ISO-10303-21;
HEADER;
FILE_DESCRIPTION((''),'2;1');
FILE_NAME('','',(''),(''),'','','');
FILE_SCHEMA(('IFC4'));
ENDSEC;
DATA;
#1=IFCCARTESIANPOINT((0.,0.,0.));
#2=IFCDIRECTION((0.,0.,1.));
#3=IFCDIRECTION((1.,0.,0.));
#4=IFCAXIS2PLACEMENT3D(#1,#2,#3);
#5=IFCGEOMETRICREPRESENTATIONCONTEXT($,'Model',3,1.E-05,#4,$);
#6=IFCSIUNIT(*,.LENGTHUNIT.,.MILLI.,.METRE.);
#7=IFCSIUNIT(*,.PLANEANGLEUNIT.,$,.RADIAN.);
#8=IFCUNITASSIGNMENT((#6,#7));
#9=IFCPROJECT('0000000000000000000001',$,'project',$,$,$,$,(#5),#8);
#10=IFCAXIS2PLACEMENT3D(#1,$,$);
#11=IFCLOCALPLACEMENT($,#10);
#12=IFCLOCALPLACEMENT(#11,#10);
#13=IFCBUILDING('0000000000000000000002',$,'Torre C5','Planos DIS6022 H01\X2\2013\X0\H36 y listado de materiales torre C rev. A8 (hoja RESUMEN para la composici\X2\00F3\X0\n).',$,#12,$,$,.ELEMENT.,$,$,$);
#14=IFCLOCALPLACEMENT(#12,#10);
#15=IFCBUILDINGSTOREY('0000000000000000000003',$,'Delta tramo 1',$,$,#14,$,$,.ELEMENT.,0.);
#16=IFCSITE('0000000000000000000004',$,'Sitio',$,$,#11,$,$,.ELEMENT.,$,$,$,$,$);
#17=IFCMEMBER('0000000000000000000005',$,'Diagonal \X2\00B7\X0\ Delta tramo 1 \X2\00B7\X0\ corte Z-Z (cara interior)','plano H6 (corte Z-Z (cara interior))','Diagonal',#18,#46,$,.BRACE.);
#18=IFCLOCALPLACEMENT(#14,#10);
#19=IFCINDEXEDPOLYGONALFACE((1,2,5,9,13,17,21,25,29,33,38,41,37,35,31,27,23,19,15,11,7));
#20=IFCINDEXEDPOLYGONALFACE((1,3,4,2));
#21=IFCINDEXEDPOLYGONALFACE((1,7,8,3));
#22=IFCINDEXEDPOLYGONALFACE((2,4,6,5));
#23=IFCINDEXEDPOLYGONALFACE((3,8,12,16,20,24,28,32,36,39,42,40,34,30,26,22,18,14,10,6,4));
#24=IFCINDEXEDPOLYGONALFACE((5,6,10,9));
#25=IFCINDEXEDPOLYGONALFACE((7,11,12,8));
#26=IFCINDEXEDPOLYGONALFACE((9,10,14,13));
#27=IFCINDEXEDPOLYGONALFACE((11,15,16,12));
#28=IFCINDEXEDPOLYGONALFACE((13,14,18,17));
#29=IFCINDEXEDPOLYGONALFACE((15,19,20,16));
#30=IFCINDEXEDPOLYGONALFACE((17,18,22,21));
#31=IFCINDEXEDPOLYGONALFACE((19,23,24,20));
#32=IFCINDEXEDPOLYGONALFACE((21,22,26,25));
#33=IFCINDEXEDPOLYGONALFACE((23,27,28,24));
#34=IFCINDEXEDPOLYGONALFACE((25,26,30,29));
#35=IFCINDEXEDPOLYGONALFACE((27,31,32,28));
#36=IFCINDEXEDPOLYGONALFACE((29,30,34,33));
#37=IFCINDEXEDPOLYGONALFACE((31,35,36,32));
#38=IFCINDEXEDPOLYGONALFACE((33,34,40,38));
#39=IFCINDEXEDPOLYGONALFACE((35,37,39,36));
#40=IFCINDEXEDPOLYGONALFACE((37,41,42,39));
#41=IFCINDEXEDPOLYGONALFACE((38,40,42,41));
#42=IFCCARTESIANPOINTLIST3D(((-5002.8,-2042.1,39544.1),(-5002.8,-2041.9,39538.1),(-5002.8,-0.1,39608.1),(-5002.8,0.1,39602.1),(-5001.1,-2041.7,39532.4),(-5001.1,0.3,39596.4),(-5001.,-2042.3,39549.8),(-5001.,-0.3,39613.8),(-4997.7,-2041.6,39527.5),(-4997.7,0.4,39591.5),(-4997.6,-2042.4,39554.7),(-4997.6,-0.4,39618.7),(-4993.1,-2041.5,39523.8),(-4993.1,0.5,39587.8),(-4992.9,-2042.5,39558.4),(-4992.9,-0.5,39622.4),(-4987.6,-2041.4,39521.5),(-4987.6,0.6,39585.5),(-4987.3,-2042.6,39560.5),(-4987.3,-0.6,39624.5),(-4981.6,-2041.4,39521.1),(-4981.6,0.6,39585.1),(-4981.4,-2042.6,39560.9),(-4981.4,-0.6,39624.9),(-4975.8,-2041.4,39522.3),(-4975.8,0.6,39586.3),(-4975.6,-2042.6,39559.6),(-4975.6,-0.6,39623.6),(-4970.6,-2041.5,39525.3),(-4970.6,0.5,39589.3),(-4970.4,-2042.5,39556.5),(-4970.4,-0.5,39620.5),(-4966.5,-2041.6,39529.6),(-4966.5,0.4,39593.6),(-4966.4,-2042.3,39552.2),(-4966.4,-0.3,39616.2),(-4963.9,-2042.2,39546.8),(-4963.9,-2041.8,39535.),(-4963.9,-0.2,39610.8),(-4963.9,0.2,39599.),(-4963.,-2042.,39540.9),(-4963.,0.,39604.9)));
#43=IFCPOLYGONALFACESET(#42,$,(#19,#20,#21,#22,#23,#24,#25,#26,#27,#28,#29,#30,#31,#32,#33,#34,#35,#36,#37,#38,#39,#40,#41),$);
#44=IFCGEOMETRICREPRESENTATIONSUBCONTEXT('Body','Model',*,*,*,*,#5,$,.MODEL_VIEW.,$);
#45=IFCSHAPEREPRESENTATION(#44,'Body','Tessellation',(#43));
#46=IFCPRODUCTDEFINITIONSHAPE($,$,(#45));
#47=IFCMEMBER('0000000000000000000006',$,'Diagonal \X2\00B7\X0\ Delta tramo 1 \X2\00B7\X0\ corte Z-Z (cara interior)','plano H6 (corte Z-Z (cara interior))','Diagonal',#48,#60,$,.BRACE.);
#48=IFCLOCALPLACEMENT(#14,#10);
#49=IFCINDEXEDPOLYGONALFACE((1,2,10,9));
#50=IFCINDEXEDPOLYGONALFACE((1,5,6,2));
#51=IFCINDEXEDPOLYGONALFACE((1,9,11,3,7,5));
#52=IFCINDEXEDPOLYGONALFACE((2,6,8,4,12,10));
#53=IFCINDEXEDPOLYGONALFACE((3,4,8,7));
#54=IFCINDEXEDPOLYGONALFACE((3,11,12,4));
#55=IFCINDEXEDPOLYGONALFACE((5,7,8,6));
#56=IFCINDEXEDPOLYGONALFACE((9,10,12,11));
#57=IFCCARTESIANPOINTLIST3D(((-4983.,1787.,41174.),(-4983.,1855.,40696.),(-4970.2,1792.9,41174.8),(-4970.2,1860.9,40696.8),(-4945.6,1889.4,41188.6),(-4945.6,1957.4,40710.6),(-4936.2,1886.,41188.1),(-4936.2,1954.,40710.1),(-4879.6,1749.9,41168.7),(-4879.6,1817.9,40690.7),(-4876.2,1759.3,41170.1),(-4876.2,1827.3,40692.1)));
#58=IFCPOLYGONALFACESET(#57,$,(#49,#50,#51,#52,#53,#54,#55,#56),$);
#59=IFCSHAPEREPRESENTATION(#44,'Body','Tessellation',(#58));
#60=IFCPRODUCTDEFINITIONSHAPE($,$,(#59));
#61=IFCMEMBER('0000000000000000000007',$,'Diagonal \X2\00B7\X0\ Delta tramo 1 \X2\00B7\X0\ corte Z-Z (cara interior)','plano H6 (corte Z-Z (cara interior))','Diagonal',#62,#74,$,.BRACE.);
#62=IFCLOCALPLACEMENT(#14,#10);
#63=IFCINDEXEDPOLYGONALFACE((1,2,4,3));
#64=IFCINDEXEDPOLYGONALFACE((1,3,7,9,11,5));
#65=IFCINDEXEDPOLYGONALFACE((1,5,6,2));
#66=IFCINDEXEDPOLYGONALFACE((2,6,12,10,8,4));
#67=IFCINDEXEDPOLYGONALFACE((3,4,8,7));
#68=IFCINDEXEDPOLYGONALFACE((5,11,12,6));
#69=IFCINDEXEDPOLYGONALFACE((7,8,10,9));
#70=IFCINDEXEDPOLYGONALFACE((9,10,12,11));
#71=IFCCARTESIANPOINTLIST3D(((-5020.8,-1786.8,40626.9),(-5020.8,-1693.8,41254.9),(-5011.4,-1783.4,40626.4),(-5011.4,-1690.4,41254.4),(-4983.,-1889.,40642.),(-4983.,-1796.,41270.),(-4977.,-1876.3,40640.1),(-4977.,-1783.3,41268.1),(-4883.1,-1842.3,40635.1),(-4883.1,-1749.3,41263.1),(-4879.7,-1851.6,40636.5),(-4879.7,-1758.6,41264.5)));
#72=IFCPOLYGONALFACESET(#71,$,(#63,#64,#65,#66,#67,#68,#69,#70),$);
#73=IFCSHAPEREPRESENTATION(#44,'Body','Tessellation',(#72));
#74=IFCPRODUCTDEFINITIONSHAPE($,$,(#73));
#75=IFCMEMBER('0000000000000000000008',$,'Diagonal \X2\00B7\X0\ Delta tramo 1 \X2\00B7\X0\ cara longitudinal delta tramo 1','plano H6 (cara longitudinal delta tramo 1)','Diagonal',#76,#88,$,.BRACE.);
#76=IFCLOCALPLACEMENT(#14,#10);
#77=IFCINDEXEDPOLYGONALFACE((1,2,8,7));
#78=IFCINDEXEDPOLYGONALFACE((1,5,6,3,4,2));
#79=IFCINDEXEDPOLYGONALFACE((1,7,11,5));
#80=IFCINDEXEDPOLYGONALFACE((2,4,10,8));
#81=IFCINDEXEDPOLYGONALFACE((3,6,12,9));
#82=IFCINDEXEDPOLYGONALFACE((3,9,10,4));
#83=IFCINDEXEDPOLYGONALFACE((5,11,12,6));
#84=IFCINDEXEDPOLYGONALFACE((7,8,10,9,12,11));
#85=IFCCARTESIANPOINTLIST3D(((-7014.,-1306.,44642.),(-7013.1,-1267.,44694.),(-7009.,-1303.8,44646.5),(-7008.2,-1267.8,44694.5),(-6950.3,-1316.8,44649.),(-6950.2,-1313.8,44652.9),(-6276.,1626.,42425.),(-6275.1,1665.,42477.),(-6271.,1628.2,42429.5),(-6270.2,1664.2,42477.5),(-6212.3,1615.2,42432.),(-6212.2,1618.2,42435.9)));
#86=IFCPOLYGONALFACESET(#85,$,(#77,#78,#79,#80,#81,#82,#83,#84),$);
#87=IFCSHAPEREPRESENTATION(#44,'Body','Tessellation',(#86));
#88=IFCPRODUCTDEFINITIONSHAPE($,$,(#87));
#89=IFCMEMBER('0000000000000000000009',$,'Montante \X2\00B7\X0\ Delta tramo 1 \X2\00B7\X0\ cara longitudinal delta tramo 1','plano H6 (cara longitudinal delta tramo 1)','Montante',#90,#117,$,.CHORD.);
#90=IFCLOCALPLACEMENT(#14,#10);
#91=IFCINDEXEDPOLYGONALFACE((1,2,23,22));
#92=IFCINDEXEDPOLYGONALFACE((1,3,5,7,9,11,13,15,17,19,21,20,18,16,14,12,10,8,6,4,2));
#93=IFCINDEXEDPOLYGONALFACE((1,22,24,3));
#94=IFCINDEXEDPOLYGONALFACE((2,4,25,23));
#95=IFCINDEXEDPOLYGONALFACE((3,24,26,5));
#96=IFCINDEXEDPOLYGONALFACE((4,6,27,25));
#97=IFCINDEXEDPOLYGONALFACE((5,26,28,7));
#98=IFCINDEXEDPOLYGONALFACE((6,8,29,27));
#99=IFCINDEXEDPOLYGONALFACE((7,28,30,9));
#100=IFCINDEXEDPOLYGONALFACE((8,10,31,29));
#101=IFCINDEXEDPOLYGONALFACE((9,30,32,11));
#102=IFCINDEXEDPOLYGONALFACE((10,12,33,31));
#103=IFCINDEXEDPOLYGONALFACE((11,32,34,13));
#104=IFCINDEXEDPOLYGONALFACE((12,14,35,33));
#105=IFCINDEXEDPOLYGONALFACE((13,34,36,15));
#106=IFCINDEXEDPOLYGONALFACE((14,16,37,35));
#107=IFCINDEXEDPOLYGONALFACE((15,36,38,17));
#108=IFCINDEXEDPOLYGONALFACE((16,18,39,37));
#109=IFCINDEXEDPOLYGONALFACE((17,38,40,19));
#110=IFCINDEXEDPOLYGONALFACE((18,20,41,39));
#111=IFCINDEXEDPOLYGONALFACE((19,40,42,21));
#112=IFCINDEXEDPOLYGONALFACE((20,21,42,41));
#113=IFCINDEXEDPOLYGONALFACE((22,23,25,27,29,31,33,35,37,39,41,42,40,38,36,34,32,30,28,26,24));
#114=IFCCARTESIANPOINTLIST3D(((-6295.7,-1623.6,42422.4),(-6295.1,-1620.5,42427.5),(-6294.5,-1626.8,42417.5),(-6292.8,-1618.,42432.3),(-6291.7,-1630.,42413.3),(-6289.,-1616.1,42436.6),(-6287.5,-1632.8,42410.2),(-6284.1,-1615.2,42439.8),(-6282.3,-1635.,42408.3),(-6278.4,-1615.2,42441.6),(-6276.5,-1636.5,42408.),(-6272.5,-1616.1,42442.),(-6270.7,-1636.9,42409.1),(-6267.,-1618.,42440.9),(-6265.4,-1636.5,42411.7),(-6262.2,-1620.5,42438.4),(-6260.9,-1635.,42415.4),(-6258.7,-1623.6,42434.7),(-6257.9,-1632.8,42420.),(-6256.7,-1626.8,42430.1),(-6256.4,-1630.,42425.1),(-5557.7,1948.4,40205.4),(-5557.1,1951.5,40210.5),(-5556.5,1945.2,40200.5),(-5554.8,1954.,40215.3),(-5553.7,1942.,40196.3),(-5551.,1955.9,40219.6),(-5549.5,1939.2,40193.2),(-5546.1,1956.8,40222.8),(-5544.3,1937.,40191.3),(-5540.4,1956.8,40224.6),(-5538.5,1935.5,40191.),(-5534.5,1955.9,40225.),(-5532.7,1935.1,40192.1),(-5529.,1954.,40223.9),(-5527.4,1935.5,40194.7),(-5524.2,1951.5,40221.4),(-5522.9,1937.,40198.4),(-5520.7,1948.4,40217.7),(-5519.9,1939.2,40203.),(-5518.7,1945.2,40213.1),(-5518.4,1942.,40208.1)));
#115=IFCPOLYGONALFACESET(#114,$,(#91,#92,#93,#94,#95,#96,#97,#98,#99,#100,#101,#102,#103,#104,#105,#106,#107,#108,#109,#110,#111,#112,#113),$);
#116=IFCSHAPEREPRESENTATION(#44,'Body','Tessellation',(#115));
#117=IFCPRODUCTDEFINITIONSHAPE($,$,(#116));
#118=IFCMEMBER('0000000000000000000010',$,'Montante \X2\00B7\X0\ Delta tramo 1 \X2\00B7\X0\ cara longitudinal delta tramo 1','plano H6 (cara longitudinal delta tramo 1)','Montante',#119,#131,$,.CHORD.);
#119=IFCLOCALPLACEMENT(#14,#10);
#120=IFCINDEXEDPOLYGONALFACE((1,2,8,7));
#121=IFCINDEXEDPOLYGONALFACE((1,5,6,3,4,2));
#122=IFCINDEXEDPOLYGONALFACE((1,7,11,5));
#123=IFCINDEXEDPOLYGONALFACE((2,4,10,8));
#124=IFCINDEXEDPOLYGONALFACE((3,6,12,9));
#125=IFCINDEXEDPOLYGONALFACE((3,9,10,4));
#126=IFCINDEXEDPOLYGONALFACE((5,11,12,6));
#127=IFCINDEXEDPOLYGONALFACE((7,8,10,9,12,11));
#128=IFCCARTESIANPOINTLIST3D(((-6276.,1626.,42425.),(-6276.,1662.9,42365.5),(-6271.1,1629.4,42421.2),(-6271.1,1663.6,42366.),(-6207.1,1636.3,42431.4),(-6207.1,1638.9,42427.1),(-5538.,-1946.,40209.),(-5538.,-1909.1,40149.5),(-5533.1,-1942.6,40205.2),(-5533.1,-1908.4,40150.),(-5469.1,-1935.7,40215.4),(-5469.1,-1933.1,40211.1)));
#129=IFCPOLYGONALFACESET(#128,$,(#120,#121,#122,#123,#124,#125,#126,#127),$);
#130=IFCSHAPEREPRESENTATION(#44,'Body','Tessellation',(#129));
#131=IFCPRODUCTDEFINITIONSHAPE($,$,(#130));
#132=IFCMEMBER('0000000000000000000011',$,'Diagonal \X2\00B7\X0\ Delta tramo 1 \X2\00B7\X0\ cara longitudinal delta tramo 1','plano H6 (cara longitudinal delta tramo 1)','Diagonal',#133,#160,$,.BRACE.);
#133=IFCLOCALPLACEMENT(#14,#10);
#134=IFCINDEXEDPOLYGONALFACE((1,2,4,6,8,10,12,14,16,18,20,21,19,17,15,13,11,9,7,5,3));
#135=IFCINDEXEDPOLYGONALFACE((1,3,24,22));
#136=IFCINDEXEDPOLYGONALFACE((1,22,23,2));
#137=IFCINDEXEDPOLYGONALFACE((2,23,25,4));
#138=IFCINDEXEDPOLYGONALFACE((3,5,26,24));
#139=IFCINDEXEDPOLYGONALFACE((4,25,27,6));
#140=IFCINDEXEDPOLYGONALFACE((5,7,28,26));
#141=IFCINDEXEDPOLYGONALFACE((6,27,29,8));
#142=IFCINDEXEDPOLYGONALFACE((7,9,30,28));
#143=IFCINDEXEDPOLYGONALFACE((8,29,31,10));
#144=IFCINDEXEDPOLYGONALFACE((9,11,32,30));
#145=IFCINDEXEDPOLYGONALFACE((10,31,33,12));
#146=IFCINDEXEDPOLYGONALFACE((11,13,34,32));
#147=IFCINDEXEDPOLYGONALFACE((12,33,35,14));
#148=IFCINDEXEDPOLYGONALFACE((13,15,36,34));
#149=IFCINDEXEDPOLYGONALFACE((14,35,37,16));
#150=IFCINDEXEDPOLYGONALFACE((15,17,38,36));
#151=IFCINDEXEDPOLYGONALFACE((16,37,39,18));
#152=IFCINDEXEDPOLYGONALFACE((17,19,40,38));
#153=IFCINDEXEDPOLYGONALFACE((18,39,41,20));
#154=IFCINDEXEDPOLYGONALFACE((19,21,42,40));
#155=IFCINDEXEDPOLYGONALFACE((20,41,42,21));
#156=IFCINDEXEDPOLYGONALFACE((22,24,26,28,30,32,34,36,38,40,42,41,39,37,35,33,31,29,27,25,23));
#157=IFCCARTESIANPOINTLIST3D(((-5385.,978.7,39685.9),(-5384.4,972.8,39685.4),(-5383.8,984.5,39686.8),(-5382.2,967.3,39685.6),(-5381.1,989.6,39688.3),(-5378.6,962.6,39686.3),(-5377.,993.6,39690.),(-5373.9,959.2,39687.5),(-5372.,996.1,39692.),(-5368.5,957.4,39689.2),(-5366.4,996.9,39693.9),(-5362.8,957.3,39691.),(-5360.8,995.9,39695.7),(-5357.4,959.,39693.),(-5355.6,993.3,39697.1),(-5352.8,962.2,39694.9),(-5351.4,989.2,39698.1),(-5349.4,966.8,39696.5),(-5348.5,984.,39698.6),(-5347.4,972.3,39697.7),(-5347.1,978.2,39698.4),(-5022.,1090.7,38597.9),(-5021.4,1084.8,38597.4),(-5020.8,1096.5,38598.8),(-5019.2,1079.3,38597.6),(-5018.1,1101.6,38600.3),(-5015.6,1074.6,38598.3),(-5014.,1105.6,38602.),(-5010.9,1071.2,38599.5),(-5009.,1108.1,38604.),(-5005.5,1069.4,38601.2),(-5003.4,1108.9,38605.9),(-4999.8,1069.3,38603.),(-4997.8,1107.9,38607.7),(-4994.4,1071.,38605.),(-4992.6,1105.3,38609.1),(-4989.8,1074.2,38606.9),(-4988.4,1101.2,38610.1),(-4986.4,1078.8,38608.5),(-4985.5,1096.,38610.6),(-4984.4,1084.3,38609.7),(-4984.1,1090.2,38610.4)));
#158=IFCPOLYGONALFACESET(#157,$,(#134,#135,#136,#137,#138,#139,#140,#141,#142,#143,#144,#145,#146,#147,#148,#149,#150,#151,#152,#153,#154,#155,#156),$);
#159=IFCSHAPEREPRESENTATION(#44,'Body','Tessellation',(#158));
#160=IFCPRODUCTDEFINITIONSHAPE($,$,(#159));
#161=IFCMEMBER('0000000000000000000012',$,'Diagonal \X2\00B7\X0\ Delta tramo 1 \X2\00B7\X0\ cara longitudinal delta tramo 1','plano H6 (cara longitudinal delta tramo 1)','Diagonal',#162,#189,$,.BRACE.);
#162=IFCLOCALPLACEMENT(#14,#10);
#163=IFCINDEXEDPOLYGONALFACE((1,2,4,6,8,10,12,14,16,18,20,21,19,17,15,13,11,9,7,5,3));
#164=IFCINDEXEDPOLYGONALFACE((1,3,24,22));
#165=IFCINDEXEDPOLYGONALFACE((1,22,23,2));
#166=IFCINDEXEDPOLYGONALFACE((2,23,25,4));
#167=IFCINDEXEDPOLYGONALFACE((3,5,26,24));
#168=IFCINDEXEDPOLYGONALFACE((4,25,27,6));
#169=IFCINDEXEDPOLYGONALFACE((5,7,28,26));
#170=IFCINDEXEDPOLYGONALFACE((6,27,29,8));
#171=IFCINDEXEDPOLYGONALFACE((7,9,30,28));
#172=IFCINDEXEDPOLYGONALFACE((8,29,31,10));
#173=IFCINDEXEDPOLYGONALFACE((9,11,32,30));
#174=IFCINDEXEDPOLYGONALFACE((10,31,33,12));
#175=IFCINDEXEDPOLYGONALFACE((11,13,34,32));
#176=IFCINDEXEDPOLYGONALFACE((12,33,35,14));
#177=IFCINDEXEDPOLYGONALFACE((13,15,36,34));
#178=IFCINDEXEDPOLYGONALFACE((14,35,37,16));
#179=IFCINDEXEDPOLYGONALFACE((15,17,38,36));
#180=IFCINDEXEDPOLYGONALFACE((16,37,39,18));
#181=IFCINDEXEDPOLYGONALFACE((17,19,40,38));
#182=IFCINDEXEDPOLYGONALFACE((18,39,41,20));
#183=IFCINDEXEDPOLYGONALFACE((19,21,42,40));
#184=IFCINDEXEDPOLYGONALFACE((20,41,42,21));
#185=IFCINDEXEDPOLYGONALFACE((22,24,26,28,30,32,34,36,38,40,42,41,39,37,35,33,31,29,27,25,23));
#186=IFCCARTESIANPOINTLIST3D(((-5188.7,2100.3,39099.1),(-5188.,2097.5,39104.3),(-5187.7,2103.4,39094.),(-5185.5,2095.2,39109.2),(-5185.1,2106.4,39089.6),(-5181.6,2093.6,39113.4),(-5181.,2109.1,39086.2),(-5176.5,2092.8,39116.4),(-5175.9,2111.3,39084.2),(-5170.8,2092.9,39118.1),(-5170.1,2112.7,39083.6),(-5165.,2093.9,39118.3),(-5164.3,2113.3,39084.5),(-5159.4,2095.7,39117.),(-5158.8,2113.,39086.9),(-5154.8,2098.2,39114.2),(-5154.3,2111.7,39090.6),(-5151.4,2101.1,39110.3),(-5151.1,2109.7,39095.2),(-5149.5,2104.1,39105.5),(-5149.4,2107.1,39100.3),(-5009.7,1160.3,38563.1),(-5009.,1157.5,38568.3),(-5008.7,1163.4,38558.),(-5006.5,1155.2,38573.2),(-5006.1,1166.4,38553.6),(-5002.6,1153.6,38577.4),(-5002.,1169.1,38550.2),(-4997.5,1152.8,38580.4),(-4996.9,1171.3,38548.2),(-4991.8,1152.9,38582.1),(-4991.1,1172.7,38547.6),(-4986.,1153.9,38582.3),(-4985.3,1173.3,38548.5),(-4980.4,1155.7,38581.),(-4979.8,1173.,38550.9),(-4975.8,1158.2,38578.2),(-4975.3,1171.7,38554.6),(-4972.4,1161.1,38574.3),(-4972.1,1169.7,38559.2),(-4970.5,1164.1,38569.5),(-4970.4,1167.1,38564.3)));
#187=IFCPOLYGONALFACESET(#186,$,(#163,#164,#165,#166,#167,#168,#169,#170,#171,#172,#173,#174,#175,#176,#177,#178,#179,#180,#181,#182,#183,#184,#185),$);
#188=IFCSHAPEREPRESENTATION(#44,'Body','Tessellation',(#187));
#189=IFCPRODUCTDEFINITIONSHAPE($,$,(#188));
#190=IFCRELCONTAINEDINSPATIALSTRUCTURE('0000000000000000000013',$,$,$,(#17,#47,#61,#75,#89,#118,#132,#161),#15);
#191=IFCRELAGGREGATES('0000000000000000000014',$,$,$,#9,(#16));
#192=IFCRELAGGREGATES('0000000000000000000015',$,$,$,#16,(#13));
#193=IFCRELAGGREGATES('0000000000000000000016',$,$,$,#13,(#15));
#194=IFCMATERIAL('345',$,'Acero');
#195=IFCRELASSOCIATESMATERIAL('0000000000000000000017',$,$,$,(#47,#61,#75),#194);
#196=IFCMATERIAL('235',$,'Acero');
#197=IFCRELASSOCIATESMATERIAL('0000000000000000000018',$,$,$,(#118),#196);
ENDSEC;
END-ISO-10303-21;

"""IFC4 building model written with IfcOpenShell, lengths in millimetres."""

from ifc_helpers import new_model, si_unit, frame, frame_2d, origin, origin_with_axes, place, context, subcontext, project, spatial, circle, l_section, extrude, material, element, save


model = new_model("IFC4")

# Units and contexts
model_context = context("Model", 3, precision=1e-05, world=origin_with_axes())
body_context = subcontext(model_context, "Body", "Model", "MODEL_VIEW")
ifc_project = project(units=[si_unit("LENGTHUNIT", "METRE", prefix="MILLI"), si_unit("PLANEANGLEUNIT", "RADIAN")], contexts=[model_context])

# Site, building, storey
site_placement = place(None, origin())
site = spatial("IfcSite", under=ifc_project, at=site_placement, Name="Sitio", CompositionType="ELEMENT")
building_placement = place(site_placement, origin())
building = spatial("IfcBuilding", under=site, at=building_placement, Name="Torre C5", Description="Planos DIS6022 H01–H36 y listado de materiales torre C rev. A8 (hoja RESUMEN para la composición).", CompositionType="ELEMENT")
storey_placement = place(building_placement, origin())
storey = spatial("IfcBuildingStorey", under=building, at=storey_placement, Name="Delta tramo 1", CompositionType="ELEMENT", Elevation=0.0)

# Members
ifc_material_1 = material(Name="235", Category="Acero")
member_1_placement = place(storey_placement, frame((-4983.0, -2042.0, 39541.0), z_axis=(0.0, 0.999509, 0.031326), x_axis=(0.999979, 0.000201, -0.006415)))
element("IfcMember", 1, at=member_1_placement, inside=storey, Name="Diagonal · Delta tramo 1 · corte Z-Z (cara interior)", Description="plano H6 (corte Z-Z (cara interior))", ObjectType="Diagonal", PredefinedType="BRACE", context=body_context, shape_type="SweptSolid", body=[
    extrude(circle(Radius=20.0), None, (0.0, 0.0, 1.0), 2043.0),
])
ifc_material_2 = material(Name="345", Category="Acero")
member_2_placement = place(storey_placement, frame((-4983.0, 1855.0, 40696.0), z_axis=(0.0, -0.140841, 0.990032), x_axis=(0.940347, -0.336826, -0.047917)))
element("IfcMember", 2, at=member_2_placement, inside=storey, material=ifc_material_2, Name="Diagonal · Delta tramo 1 · corte Z-Z (cara interior)", Description="plano H6 (corte Z-Z (cara interior))", ObjectType="Diagonal", PredefinedType="BRACE", context=body_context, shape_type="SweptSolid", body=[
    extrude(l_section(Depth=110.0, Width=110.0, Thickness=10.0, at=frame_2d((55.0, 55.0))), None, (0.0, 0.0, 1.0), 482.8),
])
member_3_placement = place(storey_placement, frame((-4983.0, -1889.0, 40642.0), z_axis=(0.0, 0.146492, 0.989212), x_axis=(0.939149, 0.339805, -0.050321)))
element("IfcMember", 3, at=member_3_placement, inside=storey, material=ifc_material_2, Name="Diagonal · Delta tramo 1 · corte Z-Z (cara interior)", Description="plano H6 (corte Z-Z (cara interior))", ObjectType="Diagonal", PredefinedType="BRACE", context=body_context, shape_type="SweptSolid", body=[
    extrude(l_section(Depth=110.0, Width=110.0, Thickness=10.0, at=frame_2d((55.0, 55.0))), None, (0.0, 0.0, 1.0), 634.8),
])
member_4_placement = place(storey_placement, frame((-6276.0, 1626.0, 42425.0), z_axis=(-0.196843, -0.782037, 0.591329), x_axis=(0.980328, -0.165892, 0.106941)))
element("IfcMember", 4, at=member_4_placement, inside=storey, material=ifc_material_2, Name="Diagonal · Delta tramo 1 · cara longitudinal delta tramo 1", Description="plano H6 (cara longitudinal delta tramo 1)", ObjectType="Diagonal", PredefinedType="BRACE", context=body_context, shape_type="SweptSolid", body=[
    extrude(l_section(Depth=65.0, Width=65.0, Thickness=5.0, at=frame_2d((32.5, 32.5))), None, (0.0, 0.0, 1.0), 3749.2),
])
member_5_placement = place(storey_placement, frame((-5538.0, 1946.0, 40208.0), z_axis=(-0.1729, -0.836855, 0.519403), x_axis=(0.264314, -0.547425, -0.794018)))
element("IfcMember", 5, at=member_5_placement, inside=storey, Name="Montante · Delta tramo 1 · cara longitudinal delta tramo 1", Description="plano H6 (cara longitudinal delta tramo 1)", ObjectType="Montante", PredefinedType="CHORD", context=body_context, shape_type="SweptSolid", body=[
    extrude(circle(Radius=20.0), None, (0.0, 0.0, 1.0), 4268.4),
])
member_6_placement = place(storey_placement, frame((-5538.0, -1946.0, 40209.0), z_axis=(-0.172921, 0.836957, 0.519232), x_axis=(0.984936, 0.146941, 0.091159)))
element("IfcMember", 6, at=member_6_placement, inside=storey, material=ifc_material_1, Name="Montante · Delta tramo 1 · cara longitudinal delta tramo 1", Description="plano H6 (cara longitudinal delta tramo 1)", ObjectType="Montante", PredefinedType="CHORD", context=body_context, shape_type="SweptSolid", body=[
    extrude(l_section(Depth=70.0, Width=70.0, Thickness=5.0, at=frame_2d((35.0, 35.0))), None, (0.0, 0.0, 1.0), 4267.8),
])
member_7_placement = place(storey_placement, frame((-5366.0, 977.0, 39692.0), z_axis=(0.314991, 0.097187, -0.944106), x_axis=(0.929313, -0.233618, 0.286007)))
element("IfcMember", 7, at=member_7_placement, inside=storey, Name="Diagonal · Delta tramo 1 · cara longitudinal delta tramo 1", Description="plano H6 (cara longitudinal delta tramo 1)", ObjectType="Diagonal", PredefinedType="BRACE", context=body_context, shape_type="SweptSolid", body=[
    extrude(circle(Radius=20.0), None, (0.0, 0.0, 1.0), 1152.4),
])
member_8_placement = place(storey_placement, frame((-5169.0, 2103.0, 39101.0), z_axis=(0.163204, -0.85705, -0.488701), x_axis=(0.972761, 0.057136, 0.224657)))
element("IfcMember", 8, at=member_8_placement, inside=storey, Name="Diagonal · Delta tramo 1 · cara longitudinal delta tramo 1", Description="plano H6 (cara longitudinal delta tramo 1)", ObjectType="Diagonal", PredefinedType="BRACE", context=body_context, shape_type="SweptSolid", body=[
    extrude(circle(Radius=20.0), None, (0.0, 0.0, 1.0), 1096.8),
])

save(model, "model.ifc")
